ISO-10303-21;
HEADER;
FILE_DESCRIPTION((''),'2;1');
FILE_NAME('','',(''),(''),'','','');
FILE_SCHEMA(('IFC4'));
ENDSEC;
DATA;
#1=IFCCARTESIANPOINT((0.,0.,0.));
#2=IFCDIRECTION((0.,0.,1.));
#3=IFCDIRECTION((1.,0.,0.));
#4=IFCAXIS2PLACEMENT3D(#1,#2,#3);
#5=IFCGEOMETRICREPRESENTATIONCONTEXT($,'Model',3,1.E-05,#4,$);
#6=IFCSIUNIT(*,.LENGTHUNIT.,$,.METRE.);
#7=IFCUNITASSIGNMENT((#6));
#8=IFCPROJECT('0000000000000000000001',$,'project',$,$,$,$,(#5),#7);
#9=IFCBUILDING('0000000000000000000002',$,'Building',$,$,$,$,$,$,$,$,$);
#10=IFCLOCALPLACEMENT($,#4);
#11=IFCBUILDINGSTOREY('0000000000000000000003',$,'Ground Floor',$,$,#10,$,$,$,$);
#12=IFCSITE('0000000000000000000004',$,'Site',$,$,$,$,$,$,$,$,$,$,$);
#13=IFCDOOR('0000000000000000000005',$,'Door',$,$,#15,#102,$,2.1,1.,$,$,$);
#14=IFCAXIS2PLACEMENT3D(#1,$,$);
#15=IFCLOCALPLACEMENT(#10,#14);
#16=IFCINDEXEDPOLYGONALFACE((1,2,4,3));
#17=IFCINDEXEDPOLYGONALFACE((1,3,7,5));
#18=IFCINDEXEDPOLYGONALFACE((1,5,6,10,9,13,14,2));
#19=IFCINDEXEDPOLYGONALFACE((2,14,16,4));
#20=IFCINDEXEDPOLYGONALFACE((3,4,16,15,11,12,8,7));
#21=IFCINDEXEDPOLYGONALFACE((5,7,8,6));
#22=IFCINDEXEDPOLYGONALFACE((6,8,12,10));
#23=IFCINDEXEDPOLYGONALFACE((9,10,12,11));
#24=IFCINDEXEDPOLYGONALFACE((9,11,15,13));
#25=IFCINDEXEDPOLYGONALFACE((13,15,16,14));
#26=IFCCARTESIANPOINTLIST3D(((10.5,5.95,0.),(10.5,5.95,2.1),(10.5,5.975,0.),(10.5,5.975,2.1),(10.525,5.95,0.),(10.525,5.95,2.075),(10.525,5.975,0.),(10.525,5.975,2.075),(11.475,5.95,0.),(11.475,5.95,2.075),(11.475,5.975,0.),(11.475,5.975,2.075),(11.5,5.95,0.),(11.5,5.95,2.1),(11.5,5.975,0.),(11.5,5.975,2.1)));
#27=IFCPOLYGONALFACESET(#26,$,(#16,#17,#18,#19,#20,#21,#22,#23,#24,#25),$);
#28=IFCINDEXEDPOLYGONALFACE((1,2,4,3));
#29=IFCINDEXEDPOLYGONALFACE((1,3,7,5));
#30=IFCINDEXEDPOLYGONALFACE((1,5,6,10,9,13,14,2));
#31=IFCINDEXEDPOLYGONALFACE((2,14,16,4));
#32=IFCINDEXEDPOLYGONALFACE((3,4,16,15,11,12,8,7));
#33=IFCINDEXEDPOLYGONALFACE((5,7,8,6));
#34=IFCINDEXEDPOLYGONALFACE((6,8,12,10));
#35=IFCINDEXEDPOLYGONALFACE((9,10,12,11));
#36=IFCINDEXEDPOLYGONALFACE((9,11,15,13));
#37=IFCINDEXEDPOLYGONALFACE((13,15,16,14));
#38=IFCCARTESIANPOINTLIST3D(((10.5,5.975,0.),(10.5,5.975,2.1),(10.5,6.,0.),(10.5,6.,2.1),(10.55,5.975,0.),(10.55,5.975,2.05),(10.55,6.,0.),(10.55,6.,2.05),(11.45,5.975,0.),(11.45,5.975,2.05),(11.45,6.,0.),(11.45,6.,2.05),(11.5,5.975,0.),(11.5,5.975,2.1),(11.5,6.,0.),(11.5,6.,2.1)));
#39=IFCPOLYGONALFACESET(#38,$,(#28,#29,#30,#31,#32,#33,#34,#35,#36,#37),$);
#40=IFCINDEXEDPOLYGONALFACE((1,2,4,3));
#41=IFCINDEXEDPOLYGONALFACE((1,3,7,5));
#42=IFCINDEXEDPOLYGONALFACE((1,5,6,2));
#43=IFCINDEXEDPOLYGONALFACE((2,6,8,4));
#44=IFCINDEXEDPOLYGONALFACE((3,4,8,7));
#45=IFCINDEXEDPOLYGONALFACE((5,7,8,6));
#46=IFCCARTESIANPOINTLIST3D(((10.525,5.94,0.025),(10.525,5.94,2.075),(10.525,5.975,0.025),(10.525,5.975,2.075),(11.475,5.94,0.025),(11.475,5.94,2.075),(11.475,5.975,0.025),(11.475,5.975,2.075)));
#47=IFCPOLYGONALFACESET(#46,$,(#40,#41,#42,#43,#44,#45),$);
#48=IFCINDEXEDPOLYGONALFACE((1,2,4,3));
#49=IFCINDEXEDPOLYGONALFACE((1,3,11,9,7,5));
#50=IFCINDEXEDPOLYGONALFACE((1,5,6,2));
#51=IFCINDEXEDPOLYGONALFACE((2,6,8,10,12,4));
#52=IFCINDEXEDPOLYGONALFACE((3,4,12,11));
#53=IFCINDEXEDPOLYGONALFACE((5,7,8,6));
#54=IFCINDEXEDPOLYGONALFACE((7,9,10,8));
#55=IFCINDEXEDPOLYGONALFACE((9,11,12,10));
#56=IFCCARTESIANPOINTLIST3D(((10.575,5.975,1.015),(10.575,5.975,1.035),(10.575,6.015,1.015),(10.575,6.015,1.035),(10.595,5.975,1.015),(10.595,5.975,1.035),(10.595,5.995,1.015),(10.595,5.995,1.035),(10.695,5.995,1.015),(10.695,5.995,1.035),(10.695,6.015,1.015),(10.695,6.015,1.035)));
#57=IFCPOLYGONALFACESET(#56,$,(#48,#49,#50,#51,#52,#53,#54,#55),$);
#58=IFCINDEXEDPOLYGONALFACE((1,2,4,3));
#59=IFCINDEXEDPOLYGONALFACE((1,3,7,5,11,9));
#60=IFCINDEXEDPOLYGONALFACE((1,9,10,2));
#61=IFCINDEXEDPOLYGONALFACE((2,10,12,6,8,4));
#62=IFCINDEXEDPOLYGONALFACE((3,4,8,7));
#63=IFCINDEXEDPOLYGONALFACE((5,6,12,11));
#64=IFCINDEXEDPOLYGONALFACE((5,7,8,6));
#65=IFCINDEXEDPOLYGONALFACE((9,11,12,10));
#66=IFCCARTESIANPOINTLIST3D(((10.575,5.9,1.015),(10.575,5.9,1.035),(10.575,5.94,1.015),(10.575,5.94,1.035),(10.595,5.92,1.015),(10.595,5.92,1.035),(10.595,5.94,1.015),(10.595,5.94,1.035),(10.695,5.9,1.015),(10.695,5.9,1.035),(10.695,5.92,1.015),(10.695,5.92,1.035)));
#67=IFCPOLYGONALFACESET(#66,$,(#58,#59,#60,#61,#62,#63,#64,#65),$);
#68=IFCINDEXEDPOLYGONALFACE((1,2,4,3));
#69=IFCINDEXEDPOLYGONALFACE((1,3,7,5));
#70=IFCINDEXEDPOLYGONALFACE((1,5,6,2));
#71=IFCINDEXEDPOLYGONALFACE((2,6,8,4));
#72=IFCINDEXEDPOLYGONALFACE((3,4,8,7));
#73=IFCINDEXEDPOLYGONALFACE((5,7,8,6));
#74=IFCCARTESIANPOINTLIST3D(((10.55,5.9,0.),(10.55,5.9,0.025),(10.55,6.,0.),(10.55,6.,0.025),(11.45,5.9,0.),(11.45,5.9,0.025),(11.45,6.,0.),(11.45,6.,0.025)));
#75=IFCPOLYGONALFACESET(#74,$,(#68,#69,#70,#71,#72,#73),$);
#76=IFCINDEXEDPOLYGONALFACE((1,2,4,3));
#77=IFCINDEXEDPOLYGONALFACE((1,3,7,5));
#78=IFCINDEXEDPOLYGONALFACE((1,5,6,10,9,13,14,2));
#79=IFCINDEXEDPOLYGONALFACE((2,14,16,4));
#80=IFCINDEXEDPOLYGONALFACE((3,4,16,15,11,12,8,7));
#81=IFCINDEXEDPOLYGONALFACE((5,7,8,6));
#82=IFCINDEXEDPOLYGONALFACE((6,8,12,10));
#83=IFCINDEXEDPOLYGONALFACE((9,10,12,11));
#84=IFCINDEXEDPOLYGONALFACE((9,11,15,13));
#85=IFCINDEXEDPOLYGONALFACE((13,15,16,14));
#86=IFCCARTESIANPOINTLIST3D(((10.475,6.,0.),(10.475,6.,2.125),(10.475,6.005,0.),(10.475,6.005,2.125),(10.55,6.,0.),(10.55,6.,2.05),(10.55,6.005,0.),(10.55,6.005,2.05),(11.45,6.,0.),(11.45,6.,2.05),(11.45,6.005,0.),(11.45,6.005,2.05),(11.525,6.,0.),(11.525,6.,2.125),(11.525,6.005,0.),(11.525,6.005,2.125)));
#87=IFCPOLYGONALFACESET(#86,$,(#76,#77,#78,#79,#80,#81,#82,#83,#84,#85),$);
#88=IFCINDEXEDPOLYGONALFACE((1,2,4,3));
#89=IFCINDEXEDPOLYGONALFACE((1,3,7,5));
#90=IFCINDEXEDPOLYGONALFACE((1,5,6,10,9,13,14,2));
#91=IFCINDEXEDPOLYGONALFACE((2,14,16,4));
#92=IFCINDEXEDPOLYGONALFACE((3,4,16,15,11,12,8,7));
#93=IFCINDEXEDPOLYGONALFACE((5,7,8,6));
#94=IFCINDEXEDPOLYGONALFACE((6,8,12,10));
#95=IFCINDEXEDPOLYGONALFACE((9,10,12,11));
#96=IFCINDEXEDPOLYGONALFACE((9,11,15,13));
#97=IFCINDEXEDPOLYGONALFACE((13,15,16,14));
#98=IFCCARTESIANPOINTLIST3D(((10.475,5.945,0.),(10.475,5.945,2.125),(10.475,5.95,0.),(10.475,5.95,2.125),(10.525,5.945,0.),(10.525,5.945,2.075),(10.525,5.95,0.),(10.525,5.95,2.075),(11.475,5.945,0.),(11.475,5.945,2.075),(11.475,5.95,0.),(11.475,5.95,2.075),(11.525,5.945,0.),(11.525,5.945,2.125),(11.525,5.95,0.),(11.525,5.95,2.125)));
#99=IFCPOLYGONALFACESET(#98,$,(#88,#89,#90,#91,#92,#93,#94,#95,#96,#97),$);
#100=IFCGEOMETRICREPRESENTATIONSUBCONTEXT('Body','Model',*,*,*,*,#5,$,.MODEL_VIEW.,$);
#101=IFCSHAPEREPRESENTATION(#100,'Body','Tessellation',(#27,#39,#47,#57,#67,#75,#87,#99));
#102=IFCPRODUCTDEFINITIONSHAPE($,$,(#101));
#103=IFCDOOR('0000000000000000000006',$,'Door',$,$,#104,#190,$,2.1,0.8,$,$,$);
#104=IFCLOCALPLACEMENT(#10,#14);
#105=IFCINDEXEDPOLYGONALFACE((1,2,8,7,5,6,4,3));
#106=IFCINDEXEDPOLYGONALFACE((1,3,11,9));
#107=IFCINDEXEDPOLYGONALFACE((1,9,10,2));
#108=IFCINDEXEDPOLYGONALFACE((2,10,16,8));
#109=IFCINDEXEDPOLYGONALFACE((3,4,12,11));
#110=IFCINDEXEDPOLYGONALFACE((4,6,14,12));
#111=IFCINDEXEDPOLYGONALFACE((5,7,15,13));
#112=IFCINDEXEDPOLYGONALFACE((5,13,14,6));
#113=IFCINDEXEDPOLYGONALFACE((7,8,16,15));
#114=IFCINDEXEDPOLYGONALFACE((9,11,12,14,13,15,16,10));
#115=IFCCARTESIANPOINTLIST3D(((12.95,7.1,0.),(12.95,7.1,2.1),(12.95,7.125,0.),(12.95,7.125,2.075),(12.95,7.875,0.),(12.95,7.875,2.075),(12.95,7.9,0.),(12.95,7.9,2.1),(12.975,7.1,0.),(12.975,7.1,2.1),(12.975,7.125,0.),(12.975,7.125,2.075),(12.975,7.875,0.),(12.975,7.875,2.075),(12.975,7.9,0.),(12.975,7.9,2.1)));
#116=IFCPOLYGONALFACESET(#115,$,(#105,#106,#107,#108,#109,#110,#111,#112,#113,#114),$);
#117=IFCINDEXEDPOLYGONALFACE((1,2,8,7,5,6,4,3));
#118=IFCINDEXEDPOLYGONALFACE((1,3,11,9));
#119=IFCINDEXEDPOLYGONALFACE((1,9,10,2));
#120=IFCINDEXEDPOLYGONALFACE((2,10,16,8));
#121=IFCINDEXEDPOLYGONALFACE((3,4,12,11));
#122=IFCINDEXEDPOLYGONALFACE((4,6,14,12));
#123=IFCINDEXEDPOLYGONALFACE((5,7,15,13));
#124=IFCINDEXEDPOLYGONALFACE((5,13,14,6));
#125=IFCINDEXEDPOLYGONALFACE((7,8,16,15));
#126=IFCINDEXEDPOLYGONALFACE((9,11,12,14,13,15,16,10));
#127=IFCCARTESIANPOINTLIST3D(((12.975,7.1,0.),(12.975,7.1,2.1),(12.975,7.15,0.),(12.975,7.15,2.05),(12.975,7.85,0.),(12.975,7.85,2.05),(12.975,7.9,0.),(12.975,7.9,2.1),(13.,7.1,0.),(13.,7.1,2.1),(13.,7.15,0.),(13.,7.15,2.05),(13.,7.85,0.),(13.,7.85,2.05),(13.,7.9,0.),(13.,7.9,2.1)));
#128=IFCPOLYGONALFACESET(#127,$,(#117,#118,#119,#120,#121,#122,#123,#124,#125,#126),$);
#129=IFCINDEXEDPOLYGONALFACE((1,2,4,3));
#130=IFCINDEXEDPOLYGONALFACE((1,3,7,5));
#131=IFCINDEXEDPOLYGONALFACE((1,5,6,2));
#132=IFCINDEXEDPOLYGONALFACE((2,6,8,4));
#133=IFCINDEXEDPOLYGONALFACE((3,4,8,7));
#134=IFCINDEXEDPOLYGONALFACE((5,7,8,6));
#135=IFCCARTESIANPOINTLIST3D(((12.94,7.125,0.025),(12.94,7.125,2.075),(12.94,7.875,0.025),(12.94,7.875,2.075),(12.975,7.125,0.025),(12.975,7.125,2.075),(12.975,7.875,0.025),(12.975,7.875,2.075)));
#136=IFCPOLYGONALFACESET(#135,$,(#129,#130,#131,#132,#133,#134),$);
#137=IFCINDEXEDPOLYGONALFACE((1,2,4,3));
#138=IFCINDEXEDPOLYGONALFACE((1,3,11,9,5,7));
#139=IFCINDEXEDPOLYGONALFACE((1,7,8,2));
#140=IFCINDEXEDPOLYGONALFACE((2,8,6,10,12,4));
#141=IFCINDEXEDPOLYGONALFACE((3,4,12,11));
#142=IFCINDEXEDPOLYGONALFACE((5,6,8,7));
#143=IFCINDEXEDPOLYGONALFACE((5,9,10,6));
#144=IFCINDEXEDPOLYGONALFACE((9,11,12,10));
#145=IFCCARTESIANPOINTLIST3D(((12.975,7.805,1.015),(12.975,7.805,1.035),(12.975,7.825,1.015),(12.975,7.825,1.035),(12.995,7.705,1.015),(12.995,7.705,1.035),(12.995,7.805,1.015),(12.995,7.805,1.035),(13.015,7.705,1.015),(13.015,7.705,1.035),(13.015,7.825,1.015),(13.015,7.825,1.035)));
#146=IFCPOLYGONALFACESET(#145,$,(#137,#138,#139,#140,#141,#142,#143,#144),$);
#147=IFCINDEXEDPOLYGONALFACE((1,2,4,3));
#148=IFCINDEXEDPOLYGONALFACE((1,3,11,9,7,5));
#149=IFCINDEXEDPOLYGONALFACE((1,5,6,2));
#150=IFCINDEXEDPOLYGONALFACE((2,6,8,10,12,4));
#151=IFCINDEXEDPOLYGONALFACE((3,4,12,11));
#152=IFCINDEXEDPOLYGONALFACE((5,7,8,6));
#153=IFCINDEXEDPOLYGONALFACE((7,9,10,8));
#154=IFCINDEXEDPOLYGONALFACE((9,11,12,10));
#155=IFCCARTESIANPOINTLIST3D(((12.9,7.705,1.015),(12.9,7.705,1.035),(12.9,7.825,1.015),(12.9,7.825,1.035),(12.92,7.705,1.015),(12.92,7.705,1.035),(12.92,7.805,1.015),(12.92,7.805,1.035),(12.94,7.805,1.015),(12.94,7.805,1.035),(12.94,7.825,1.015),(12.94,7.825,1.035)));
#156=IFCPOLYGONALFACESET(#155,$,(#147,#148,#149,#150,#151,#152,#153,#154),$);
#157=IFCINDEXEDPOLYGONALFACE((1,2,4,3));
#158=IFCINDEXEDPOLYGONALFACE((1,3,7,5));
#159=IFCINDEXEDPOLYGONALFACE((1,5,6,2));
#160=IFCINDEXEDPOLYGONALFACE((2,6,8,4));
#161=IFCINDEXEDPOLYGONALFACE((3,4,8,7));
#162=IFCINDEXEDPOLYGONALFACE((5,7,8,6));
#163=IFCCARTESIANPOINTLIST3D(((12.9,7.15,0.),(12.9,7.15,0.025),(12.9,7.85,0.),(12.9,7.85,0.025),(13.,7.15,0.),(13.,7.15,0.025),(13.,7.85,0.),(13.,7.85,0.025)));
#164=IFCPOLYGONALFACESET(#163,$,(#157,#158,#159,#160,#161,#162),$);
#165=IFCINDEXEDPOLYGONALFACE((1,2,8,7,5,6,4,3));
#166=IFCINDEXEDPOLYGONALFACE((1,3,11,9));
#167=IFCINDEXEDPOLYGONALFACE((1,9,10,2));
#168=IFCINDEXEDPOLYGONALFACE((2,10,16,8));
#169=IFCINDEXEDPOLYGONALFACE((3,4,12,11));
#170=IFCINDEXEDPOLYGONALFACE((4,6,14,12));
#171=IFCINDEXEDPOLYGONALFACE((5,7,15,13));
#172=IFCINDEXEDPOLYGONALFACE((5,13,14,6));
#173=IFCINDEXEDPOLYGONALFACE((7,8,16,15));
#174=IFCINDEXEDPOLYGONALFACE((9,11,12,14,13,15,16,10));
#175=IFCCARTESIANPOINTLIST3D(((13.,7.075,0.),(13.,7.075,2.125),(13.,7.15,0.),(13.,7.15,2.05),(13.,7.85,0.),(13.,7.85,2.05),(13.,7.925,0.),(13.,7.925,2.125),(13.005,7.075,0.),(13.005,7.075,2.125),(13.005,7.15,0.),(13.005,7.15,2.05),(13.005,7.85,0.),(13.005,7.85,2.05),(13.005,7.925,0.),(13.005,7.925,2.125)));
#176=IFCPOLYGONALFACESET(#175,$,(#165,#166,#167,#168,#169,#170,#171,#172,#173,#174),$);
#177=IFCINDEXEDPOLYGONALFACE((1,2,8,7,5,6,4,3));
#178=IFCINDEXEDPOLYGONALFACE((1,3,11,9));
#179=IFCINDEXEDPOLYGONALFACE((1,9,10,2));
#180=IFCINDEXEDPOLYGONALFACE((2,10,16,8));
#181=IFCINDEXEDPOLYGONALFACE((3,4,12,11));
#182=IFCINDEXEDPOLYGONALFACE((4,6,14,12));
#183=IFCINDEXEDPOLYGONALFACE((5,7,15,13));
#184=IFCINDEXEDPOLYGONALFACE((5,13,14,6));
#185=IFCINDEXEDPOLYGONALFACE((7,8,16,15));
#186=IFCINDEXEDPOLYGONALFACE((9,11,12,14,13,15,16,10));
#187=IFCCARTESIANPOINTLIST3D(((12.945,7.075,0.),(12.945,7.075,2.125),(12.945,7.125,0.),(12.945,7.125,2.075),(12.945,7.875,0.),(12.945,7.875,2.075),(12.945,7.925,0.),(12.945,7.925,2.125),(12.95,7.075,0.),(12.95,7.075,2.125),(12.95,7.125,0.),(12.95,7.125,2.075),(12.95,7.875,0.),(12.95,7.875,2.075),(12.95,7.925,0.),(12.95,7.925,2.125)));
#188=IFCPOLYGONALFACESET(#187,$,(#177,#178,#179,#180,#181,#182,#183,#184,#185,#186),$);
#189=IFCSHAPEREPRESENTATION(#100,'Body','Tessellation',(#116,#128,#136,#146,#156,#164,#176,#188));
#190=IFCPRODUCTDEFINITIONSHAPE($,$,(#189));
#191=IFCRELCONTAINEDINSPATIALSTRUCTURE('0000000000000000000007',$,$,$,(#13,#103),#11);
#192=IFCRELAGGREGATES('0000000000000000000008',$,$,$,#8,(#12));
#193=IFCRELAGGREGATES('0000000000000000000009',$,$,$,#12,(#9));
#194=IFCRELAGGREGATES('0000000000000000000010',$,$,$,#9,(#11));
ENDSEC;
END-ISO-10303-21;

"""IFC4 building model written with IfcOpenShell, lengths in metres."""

from ifc_helpers import new_model, si_unit, frame, origin_with_axes, place, context, subcontext, project, spatial, line, indexed_curve, outline, extrude, element, save


model = new_model("IFC4")

# Units and contexts
model_context = context("Model", 3, precision=1e-05, world=origin_with_axes())
body_context = subcontext(model_context, "Body", "Model", "MODEL_VIEW")
ifc_project = project(units=[si_unit("LENGTHUNIT", "METRE")], contexts=[model_context])

# Site, building, storey
site = spatial("IfcSite", under=ifc_project, Name="Site")
building = spatial("IfcBuilding", under=site, Name="Building")
storey_placement = place(None, origin_with_axes())
storey = spatial("IfcBuildingStorey", under=building, at=storey_placement, Name="Ground Floor")

# Doors
door_1_placement = place(storey_placement, frame((11.5, 6.0, 0.0), z_axis=(0.0, 0.0, 1.0), x_axis=(-1.0, 0.0, 0.0)))
element("IfcDoor", 1, at=door_1_placement, inside=storey, Name="Door", OverallHeight=2.1, OverallWidth=1.0, context=body_context, shape_type="SweptSolid", body=[
    extrude(outline(indexed_curve([(0.0, 0.0), (0.0, 2.1), (1.0, 2.1), (1.0, 0.0), (0.975, 0.0), (0.975, 2.075), (0.025, 2.075), (0.025, 0.0)], segments=[line(1, 2, 3, 4, 5, 6, 7, 8, 1)])), frame((0.0, 0.025, 0.0), z_axis=(0.0, -1.0, 0.0), x_axis=(1.0, 0.0, 0.0)), (0.0, 0.0, -1.0), 0.025),
    extrude(outline(indexed_curve([(0.0, 0.0), (0.0, 2.1), (1.0, 2.1), (1.0, 0.0), (0.95, 0.0), (0.95, 2.05), (0.05, 2.05), (0.05, 0.0)], segments=[line(1, 2, 3, 4, 5, 6, 7, 8, 1)])), frame((0.0, 0.0, 0.0), z_axis=(0.0, -1.0, 0.0), x_axis=(1.0, 0.0, 0.0)), (0.0, 0.0, -1.0), 0.025),
    extrude(outline(indexed_curve([(0.0, 0.0), (0.95, 0.0), (0.95, 0.035), (0.0, 0.035)], segments=[line(1, 2, 3, 4, 1)])), frame((0.025, 0.025, 0.025), z_axis=(0.0, 0.0, 1.0), x_axis=(1.0, 0.0, 0.0)), (0.0, 0.0, 1.0), 2.05),
    extrude(outline(indexed_curve([(0.0, 0.0), (0.0, -0.04), (-0.12, -0.04), (-0.12, -0.02), (-0.02, -0.02), (-0.02, 0.0)], segments=[line(1, 2, 3, 4, 5, 6, 1)])), frame((0.925, 0.025, 1.015), z_axis=(0.0, 0.0, 1.0), x_axis=(1.0, 0.0, 0.0)), (0.0, 0.0, 1.0), 0.02),
    extrude(outline(indexed_curve([(0.0, 0.0), (0.0, 0.04), (-0.12, 0.04), (-0.12, 0.02), (-0.02, 0.02), (-0.02, 0.0)], segments=[line(1, 2, 3, 4, 5, 6, 1)])), frame((0.925, 0.06, 1.015), z_axis=(0.0, 0.0, 1.0), x_axis=(1.0, 0.0, 0.0)), (0.0, 0.0, 1.0), 0.02),
    extrude(outline(indexed_curve([(0.0, 0.0), (0.9, 0.0), (0.9, 0.1), (0.0, 0.1)], segments=[line(1, 2, 3, 4, 1)])), frame((0.05, 0.0, 0.0), z_axis=(0.0, 0.0, 1.0), x_axis=(1.0, 0.0, 0.0)), (0.0, 0.0, 1.0), 0.025),
    extrude(outline(indexed_curve([(0.0, 0.0), (0.0, 2.125), (1.05, 2.125), (1.05, 0.0), (0.975, 0.0), (0.975, 2.05), (0.075, 2.05), (0.075, 0.0)], segments=[line(1, 2, 3, 4, 5, 6, 7, 8, 1)])), frame((-0.025, -0.005, 0.0), z_axis=(0.0, -1.0, 0.0), x_axis=(1.0, 0.0, 0.0)), (0.0, 0.0, -1.0), 0.005),
    extrude(outline(indexed_curve([(0.0, 0.0), (0.0, 2.125), (1.05, 2.125), (1.05, 0.0), (1.0, 0.0), (1.0, 2.075), (0.05, 2.075), (0.05, 0.0)], segments=[line(1, 2, 3, 4, 5, 6, 7, 8, 1)])), frame((-0.025, 0.05, 0.0), z_axis=(0.0, -1.0, 0.0), x_axis=(1.0, 0.0, 0.0)), (0.0, 0.0, -1.0), 0.005),
])
door_2_placement = place(storey_placement, frame((13.0, 7.1, 0.0), z_axis=(0.0, 0.0, 1.0), x_axis=(0.0, 1.0, 0.0)))
element("IfcDoor", 2, at=door_2_placement, inside=storey, Name="Door", OverallHeight=2.1, OverallWidth=0.8, context=body_context, shape_type="SweptSolid", body=[
    extrude(outline(indexed_curve([(0.0, 0.0), (0.0, 2.1), (0.8, 2.1), (0.8, 0.0), (0.775, 0.0), (0.775, 2.075), (0.025, 2.075), (0.025, 0.0)], segments=[line(1, 2, 3, 4, 5, 6, 7, 8, 1)])), frame((0.0, 0.025, 0.0), z_axis=(0.0, -1.0, 0.0), x_axis=(1.0, 0.0, 0.0)), (0.0, 0.0, -1.0), 0.025),
    extrude(outline(indexed_curve([(0.0, 0.0), (0.0, 2.1), (0.8, 2.1), (0.8, 0.0), (0.75, 0.0), (0.75, 2.05), (0.05, 2.05), (0.05, 0.0)], segments=[line(1, 2, 3, 4, 5, 6, 7, 8, 1)])), frame((0.0, 0.0, 0.0), z_axis=(0.0, -1.0, 0.0), x_axis=(1.0, 0.0, 0.0)), (0.0, 0.0, -1.0), 0.025),
    extrude(outline(indexed_curve([(0.0, 0.0), (0.75, 0.0), (0.75, 0.035), (0.0, 0.035)], segments=[line(1, 2, 3, 4, 1)])), frame((0.025, 0.025, 0.025), z_axis=(0.0, 0.0, 1.0), x_axis=(1.0, 0.0, 0.0)), (0.0, 0.0, 1.0), 2.05),
    extrude(outline(indexed_curve([(0.0, 0.0), (0.0, -0.04), (-0.12, -0.04), (-0.12, -0.02), (-0.02, -0.02), (-0.02, 0.0)], segments=[line(1, 2, 3, 4, 5, 6, 1)])), frame((0.725, 0.025, 1.015), z_axis=(0.0, 0.0, 1.0), x_axis=(1.0, 0.0, 0.0)), (0.0, 0.0, 1.0), 0.02),
    extrude(outline(indexed_curve([(0.0, 0.0), (0.0, 0.04), (-0.12, 0.04), (-0.12, 0.02), (-0.02, 0.02), (-0.02, 0.0)], segments=[line(1, 2, 3, 4, 5, 6, 1)])), frame((0.725, 0.06, 1.015), z_axis=(0.0, 0.0, 1.0), x_axis=(1.0, 0.0, 0.0)), (0.0, 0.0, 1.0), 0.02),
    extrude(outline(indexed_curve([(0.0, 0.0), (0.7, 0.0), (0.7, 0.1), (0.0, 0.1)], segments=[line(1, 2, 3, 4, 1)])), frame((0.05, 0.0, 0.0), z_axis=(0.0, 0.0, 1.0), x_axis=(1.0, 0.0, 0.0)), (0.0, 0.0, 1.0), 0.025),
    extrude(outline(indexed_curve([(0.0, 0.0), (0.0, 2.125), (0.85, 2.125), (0.85, 0.0), (0.775, 0.0), (0.775, 2.05), (0.075, 2.05), (0.075, 0.0)], segments=[line(1, 2, 3, 4, 5, 6, 7, 8, 1)])), frame((-0.025, -0.005, 0.0), z_axis=(0.0, -1.0, 0.0), x_axis=(1.0, 0.0, 0.0)), (0.0, 0.0, -1.0), 0.005),
    extrude(outline(indexed_curve([(0.0, 0.0), (0.0, 2.125), (0.85, 2.125), (0.85, 0.0), (0.8, 0.0), (0.8, 2.075), (0.05, 2.075), (0.05, 0.0)], segments=[line(1, 2, 3, 4, 5, 6, 7, 8, 1)])), frame((-0.025, 0.05, 0.0), z_axis=(0.0, -1.0, 0.0), x_axis=(1.0, 0.0, 0.0)), (0.0, 0.0, -1.0), 0.005),
])

save(model, "model.ifc")
